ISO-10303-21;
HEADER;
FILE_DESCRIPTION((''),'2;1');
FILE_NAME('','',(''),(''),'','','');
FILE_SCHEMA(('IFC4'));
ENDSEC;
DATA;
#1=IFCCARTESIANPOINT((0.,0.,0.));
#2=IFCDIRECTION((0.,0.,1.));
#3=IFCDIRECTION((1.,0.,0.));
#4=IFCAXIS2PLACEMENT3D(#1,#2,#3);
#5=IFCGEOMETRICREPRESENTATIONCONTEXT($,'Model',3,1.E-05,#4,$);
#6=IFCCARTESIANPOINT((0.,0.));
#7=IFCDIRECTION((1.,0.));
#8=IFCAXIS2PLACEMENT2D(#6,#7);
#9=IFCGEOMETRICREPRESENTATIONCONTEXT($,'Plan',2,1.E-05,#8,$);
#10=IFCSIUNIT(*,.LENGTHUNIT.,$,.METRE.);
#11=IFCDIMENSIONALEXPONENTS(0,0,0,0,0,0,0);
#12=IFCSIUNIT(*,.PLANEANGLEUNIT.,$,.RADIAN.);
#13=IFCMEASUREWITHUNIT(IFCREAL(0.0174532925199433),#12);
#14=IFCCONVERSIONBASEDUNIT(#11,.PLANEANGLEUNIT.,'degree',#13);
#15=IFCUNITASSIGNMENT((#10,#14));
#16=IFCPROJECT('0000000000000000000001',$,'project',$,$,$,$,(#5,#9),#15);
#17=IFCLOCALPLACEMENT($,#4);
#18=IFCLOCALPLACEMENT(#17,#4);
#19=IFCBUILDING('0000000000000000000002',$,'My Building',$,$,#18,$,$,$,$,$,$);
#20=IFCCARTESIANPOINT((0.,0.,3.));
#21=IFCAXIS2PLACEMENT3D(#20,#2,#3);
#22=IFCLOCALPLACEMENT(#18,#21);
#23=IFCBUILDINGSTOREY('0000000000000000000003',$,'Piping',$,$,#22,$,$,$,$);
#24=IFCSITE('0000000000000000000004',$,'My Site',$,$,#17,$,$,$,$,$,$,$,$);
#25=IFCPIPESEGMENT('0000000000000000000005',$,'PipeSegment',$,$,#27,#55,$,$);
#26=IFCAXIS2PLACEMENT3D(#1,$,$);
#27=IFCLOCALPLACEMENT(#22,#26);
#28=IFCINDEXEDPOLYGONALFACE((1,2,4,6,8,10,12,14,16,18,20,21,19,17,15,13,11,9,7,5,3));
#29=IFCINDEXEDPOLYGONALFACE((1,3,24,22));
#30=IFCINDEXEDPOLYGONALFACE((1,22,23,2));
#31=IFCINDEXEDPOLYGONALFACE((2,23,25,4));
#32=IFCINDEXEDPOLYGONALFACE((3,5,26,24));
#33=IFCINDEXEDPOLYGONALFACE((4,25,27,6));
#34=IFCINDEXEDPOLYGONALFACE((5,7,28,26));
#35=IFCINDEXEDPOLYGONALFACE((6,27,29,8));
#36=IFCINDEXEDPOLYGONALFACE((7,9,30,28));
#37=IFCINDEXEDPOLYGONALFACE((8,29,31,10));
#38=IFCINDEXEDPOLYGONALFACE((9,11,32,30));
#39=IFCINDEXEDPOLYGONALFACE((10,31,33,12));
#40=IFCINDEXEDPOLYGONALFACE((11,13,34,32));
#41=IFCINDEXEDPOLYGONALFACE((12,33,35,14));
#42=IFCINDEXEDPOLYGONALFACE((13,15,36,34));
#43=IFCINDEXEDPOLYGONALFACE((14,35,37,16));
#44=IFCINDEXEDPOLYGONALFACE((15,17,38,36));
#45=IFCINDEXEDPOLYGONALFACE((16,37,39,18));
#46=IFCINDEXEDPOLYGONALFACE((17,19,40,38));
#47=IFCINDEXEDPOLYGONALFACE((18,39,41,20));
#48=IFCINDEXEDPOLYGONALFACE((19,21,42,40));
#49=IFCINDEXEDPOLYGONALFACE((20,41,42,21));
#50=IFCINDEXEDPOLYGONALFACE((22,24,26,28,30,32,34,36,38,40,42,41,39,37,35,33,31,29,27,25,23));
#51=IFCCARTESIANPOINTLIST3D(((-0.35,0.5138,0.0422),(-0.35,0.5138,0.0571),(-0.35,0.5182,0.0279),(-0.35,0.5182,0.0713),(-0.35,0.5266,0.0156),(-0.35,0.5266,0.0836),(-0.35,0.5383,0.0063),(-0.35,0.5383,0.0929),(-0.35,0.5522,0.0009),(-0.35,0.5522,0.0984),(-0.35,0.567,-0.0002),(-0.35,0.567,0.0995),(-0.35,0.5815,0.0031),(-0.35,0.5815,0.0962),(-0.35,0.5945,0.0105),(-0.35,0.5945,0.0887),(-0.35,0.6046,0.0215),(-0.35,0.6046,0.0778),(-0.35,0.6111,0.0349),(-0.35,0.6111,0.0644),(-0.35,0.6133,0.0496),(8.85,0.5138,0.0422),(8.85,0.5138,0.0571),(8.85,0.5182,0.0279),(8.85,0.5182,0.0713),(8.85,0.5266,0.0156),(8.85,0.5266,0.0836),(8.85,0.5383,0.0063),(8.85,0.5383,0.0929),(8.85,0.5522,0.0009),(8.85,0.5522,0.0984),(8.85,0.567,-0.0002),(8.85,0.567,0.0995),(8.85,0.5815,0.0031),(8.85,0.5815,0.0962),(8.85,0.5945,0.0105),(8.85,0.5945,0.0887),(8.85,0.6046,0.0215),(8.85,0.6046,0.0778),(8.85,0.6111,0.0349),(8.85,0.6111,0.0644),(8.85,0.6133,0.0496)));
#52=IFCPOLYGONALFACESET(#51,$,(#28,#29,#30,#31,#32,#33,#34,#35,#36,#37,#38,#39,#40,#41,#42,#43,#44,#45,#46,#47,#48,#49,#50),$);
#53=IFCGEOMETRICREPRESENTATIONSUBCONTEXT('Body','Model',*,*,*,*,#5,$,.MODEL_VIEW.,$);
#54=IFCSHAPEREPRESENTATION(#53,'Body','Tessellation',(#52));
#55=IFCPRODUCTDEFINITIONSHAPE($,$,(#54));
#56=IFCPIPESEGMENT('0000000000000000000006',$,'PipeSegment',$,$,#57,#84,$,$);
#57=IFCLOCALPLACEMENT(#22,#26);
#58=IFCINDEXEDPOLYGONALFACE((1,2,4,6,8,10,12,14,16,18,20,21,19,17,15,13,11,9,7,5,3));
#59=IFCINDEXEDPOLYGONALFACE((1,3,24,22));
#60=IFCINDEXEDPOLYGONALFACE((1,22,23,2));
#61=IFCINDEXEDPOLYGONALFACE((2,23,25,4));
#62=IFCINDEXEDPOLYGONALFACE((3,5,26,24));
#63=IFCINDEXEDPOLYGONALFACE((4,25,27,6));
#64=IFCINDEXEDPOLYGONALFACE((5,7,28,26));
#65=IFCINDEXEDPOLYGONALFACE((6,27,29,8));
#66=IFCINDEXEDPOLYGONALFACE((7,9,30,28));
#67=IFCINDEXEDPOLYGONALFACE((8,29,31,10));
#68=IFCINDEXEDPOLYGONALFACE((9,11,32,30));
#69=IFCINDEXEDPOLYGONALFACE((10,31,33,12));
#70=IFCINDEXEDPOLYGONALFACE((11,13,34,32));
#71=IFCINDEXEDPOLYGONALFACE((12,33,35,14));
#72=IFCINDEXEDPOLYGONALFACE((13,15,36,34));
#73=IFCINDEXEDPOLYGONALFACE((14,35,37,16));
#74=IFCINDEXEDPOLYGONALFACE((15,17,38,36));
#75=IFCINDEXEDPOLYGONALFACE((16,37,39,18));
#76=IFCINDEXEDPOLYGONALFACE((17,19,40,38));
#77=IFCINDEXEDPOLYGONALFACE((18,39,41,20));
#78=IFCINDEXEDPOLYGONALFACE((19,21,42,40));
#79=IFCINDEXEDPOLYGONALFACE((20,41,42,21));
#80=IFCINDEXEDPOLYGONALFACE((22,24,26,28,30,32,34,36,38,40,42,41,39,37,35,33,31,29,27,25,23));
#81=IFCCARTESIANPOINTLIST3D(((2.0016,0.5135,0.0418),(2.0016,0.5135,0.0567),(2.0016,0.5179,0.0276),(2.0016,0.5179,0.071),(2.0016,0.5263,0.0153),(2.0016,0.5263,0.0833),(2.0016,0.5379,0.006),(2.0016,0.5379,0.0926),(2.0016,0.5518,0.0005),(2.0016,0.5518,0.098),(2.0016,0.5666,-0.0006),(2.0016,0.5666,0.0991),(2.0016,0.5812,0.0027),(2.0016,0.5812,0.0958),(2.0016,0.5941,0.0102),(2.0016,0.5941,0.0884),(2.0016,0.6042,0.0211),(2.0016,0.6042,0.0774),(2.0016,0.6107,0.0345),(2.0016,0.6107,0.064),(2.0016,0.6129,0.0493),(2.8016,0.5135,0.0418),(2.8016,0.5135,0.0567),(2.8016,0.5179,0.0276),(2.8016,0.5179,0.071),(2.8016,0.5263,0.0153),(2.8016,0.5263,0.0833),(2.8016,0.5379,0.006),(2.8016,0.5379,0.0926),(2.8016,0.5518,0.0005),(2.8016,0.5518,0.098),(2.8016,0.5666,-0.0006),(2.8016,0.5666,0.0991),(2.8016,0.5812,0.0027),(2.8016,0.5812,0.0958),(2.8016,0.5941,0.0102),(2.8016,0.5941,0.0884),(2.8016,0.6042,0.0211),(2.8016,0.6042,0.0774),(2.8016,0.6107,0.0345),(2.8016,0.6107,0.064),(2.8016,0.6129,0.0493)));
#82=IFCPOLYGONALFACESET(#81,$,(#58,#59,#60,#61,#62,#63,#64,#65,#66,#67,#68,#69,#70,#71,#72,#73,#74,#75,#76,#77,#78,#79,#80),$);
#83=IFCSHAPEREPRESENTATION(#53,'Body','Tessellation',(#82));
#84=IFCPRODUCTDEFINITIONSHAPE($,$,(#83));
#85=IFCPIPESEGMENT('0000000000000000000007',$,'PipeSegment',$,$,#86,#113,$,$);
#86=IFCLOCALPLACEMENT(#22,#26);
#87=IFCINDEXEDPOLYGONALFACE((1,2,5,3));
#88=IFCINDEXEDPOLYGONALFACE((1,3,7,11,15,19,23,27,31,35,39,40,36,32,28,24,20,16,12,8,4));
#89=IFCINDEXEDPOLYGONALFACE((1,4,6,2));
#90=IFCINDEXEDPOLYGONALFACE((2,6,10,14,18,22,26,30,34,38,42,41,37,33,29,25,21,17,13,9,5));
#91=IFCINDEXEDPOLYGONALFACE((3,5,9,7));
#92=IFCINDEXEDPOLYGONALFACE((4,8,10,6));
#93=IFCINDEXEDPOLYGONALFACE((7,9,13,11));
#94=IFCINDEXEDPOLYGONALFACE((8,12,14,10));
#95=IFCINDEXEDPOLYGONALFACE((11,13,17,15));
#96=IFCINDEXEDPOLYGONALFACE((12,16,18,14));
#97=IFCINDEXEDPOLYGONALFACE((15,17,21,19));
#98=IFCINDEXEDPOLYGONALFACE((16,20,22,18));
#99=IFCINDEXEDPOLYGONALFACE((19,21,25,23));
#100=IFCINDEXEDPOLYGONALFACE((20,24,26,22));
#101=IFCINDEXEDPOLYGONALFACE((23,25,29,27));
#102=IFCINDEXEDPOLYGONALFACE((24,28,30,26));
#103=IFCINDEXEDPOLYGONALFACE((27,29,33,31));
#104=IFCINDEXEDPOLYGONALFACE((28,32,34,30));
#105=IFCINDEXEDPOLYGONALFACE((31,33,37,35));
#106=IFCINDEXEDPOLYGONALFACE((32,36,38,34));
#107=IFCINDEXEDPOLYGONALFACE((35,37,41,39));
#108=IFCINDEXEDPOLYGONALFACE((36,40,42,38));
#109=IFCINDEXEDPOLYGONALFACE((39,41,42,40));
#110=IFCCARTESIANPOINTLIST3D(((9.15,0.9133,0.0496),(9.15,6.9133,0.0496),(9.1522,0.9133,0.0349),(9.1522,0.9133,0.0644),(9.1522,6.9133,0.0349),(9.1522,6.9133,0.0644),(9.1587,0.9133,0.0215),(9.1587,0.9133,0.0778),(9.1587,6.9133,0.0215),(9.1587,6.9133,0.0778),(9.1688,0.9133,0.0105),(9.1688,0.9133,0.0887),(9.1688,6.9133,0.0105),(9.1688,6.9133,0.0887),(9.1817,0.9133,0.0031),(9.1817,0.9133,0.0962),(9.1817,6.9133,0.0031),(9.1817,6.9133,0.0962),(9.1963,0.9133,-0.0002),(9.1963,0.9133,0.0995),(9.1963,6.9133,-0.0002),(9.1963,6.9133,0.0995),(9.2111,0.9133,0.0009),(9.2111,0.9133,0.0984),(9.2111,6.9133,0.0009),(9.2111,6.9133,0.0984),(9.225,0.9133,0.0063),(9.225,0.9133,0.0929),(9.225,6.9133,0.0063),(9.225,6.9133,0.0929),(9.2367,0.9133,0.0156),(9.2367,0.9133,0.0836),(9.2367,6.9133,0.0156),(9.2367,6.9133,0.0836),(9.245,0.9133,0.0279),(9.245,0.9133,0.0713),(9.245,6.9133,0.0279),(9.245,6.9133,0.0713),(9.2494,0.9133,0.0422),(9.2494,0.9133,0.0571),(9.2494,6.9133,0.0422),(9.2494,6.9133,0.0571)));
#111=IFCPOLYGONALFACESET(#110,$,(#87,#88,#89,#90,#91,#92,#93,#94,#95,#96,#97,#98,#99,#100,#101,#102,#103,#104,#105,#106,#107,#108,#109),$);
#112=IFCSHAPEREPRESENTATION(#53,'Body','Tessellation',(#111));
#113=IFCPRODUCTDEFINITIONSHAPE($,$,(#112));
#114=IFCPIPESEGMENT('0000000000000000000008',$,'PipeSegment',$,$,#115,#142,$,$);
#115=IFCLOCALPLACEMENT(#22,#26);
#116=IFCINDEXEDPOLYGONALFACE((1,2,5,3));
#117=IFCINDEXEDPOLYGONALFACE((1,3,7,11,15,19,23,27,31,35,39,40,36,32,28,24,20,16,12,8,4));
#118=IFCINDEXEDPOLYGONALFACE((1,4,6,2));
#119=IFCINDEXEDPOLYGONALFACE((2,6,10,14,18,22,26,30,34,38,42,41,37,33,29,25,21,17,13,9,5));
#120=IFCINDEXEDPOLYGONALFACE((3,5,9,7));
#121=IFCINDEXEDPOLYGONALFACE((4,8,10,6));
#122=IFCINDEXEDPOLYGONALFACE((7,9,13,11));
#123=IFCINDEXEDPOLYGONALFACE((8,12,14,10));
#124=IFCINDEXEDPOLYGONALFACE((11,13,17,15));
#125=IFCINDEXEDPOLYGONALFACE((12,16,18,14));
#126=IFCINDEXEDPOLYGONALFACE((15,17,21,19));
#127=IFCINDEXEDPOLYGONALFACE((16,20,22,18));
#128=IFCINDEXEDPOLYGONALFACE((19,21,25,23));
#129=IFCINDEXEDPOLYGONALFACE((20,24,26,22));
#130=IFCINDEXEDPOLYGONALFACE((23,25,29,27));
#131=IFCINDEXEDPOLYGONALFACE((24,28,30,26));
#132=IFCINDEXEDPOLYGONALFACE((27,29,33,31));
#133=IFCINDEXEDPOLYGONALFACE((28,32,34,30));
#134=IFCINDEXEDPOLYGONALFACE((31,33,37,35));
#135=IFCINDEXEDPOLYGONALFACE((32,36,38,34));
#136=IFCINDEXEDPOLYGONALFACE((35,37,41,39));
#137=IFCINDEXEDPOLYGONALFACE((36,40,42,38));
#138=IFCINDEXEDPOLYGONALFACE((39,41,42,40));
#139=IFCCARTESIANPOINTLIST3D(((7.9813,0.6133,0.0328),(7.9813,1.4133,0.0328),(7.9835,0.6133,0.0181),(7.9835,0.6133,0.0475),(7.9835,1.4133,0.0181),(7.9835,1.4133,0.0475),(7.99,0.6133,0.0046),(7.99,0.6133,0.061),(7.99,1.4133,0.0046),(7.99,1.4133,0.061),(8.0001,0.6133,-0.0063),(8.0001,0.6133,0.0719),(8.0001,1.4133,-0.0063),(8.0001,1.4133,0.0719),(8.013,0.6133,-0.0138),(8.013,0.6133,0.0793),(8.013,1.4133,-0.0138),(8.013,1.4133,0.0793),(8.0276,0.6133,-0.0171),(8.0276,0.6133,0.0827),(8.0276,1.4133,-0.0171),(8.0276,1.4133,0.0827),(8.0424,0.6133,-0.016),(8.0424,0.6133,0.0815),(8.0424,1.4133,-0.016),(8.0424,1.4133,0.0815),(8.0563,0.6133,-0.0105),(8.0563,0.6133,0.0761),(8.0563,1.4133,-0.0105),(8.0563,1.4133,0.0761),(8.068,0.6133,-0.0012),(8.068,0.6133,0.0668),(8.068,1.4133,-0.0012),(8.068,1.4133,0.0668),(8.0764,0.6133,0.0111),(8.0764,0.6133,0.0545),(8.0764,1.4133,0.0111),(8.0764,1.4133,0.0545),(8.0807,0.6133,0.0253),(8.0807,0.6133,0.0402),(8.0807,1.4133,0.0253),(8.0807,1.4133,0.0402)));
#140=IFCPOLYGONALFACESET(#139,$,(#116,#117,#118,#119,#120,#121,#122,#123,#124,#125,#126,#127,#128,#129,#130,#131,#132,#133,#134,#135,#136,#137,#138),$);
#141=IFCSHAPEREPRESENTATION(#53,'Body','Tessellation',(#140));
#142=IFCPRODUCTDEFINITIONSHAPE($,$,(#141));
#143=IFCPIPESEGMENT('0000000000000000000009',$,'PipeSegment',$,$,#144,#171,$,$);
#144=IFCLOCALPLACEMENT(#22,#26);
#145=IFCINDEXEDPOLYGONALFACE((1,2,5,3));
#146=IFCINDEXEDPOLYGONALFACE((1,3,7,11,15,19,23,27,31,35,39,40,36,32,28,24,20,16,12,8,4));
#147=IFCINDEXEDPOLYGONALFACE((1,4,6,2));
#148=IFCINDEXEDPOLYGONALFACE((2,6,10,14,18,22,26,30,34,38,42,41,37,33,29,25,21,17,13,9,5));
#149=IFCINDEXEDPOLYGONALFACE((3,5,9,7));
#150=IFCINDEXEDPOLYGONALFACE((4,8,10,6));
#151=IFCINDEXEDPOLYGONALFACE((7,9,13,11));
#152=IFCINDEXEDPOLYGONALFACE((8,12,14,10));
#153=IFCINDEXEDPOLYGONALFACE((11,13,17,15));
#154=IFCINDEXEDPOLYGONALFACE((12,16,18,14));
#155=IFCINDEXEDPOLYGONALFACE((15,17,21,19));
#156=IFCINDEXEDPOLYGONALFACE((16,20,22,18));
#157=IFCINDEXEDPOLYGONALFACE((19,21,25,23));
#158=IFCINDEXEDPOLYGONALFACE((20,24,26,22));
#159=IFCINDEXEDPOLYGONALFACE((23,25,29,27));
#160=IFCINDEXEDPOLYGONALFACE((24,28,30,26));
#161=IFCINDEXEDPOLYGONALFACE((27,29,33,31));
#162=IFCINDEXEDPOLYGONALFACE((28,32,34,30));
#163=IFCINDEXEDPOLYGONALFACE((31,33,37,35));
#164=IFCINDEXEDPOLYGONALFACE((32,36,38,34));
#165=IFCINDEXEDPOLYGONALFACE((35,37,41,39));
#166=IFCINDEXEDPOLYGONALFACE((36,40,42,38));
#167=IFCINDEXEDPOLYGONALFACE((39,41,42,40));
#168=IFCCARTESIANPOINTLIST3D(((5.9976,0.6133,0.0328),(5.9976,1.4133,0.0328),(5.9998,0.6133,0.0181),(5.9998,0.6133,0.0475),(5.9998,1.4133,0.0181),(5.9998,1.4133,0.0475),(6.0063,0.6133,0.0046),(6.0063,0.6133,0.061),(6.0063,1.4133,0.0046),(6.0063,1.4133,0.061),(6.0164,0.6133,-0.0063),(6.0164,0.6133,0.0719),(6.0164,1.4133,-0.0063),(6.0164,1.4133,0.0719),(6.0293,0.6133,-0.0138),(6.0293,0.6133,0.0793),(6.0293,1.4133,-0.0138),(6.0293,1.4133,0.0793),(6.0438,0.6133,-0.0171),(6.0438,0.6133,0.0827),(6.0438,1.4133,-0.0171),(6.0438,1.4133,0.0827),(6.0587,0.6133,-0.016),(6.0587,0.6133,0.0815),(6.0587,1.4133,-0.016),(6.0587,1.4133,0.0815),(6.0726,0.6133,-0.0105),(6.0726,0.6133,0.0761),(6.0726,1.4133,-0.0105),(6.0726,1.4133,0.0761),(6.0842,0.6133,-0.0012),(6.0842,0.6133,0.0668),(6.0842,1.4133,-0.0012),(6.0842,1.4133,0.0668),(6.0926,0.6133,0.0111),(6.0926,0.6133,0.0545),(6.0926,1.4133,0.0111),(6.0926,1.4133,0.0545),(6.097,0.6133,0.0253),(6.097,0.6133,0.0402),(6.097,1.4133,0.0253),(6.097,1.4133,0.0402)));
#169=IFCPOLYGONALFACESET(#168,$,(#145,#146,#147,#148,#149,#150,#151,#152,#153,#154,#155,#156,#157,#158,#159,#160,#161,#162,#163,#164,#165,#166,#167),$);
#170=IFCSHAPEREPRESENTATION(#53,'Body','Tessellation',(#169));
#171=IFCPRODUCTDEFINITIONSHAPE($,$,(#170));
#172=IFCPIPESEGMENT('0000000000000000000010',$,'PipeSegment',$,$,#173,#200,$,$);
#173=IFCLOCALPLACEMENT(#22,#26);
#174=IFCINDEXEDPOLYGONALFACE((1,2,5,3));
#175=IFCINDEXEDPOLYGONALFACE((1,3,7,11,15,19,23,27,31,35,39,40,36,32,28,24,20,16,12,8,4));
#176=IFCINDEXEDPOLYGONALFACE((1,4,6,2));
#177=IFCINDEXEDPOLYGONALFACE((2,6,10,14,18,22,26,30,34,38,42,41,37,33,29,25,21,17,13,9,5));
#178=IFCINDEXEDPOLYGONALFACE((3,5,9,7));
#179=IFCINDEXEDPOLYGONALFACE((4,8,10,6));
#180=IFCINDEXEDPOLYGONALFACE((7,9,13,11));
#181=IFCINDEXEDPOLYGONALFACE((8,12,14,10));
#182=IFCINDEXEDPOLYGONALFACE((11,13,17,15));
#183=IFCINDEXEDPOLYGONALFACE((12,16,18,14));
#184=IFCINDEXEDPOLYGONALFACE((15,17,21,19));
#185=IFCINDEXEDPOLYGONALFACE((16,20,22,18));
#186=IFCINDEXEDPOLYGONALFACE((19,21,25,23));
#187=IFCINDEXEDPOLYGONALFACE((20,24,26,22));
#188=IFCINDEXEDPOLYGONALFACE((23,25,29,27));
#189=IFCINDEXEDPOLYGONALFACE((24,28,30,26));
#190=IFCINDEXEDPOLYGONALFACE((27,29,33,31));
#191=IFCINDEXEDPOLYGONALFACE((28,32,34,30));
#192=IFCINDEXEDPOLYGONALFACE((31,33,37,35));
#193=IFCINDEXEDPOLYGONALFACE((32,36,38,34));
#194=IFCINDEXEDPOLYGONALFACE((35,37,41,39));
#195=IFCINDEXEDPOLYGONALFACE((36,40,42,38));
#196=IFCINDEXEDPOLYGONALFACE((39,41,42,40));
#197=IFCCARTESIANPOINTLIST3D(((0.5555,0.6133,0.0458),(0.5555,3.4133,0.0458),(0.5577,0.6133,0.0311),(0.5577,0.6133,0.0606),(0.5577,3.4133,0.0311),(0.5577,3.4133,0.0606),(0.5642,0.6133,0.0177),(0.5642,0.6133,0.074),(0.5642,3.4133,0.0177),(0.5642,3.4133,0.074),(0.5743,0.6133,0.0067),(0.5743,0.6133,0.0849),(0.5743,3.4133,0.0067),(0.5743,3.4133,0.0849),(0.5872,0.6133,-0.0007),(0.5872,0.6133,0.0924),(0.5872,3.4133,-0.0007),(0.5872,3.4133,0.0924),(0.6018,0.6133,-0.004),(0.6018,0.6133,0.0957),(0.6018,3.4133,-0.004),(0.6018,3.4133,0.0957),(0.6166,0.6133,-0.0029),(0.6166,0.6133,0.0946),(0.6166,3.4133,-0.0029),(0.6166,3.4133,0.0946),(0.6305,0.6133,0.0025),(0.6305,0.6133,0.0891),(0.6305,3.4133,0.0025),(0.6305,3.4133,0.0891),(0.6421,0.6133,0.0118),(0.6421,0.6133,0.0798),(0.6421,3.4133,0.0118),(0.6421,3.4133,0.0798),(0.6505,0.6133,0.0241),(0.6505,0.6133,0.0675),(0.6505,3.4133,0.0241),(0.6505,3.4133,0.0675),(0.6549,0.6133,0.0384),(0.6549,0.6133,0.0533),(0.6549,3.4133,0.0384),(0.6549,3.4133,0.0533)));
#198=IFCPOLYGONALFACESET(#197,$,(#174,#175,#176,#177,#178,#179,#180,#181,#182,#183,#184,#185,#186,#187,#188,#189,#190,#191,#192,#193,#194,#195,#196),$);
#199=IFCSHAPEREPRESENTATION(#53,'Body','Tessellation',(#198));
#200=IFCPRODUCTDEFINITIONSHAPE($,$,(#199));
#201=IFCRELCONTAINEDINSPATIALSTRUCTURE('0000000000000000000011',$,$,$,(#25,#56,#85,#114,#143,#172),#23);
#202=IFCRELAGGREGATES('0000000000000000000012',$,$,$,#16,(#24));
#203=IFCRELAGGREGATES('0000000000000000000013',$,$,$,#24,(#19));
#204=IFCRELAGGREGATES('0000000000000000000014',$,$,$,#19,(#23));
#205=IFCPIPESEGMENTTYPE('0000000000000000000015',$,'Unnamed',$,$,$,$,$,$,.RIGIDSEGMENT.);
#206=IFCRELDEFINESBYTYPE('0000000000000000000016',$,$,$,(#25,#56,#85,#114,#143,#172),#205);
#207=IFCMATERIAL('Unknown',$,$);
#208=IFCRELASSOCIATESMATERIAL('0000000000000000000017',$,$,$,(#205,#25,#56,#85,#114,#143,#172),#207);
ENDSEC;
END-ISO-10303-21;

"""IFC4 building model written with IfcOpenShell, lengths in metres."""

from ifc_helpers import new_model, entity, si_unit, converted_unit, frame, origin_with_axes, origin_2d_with_axis, place, context, subcontext, project, spatial, circle, extrude, material, material_profile, profile_set, profile_usage, type_object, element, save


model = new_model("IFC4")

# Units and contexts
model_context = context("Model", 3, precision=1e-05, world=origin_with_axes())
plan_context = context("Plan", 2, precision=1e-05, world=origin_2d_with_axis())
body_context = subcontext(model_context, "Body", "Model", "MODEL_VIEW")
ifc_project = project(units=[si_unit("LENGTHUNIT", "METRE"), converted_unit("PLANEANGLEUNIT", "degree", entity("IfcReal", 0.0174532925199433), si_unit("PLANEANGLEUNIT", "RADIAN"), dimensions=[0, 0, 0, 0, 0, 0, 0])], contexts=[model_context, plan_context])

# Site, building, storey
site_placement = place(None, origin_with_axes())
site = spatial("IfcSite", under=ifc_project, at=site_placement, Name="My Site")
building_placement = place(site_placement, origin_with_axes())
building = spatial("IfcBuilding", under=site, at=building_placement, Name="My Building")
storey_placement = place(building_placement, frame((0.0, 0.0, 3.0), z_axis=(0.0, 0.0, 1.0), x_axis=(1.0, 0.0, 0.0)))
storey = spatial("IfcBuildingStorey", under=building, at=storey_placement, Name="Piping")

# Pipe segments
ifc_material = material(Name="Unknown")
ifc_material_profile = material_profile(ifc_material, circle(Radius=0.05))
ifc_profile_set = profile_set([ifc_material_profile])
ifc_profile_usage_1 = profile_usage(ifc_profile_set, cardinal=5)
pipe_segment_type = type_object("IfcPipeSegmentType", Name="Unnamed", PredefinedType="RIGIDSEGMENT", material=ifc_profile_set)
pipe_segment_1_placement = place(storey_placement, frame((-0.35, 0.5633, 0.0496), z_axis=(1.0, 0.0, 0.0), x_axis=(0.0, 1.0, 0.0)))
element("IfcPipeSegment", 1, at=pipe_segment_1_placement, inside=storey, type_object=pipe_segment_type, material=ifc_profile_usage_1, Name="PipeSegment", context=body_context, shape_type="SweptSolid", body=[
    extrude(circle(Radius=0.05), origin_with_axes(), (0.0, 0.0, 1.0), 9.2),
])
ifc_profile_usage_2 = profile_usage(ifc_profile_set, cardinal=8)
pipe_segment_2_placement = place(storey_placement, frame((2.0016, 0.5629, 0.0993), z_axis=(1.0, 0.0, 0.0), x_axis=(0.0, 1.0, 0.0)))
element("IfcPipeSegment", 2, at=pipe_segment_2_placement, inside=storey, type_object=pipe_segment_type, material=ifc_profile_usage_2, Name="PipeSegment", context=body_context, shape_type="SweptSolid", body=[
    extrude(circle(Radius=0.05), frame((0.0, -0.05, 0.0), z_axis=(0.0, 0.0, 1.0), x_axis=(1.0, 0.0, 0.0)), (0.0, 0.0, 1.0), 0.8),
])
ifc_profile_usage_3 = profile_usage(ifc_profile_set, cardinal=10)
pipe_segment_3_placement = place(storey_placement, frame((9.2, 0.9133, 0.0496), z_axis=(0.0, 1.0, 0.0), x_axis=(-1.0, 0.0, 0.0)))
element("IfcPipeSegment", 3, at=pipe_segment_3_placement, inside=storey, type_object=pipe_segment_type, material=ifc_profile_usage_3, Name="PipeSegment", context=body_context, shape_type="SweptSolid", body=[
    extrude(circle(Radius=0.05), origin_with_axes(), (0.0, 0.0, 1.0), 6.0),
])
ifc_profile_usage_4 = profile_usage(ifc_profile_set, cardinal=8)
pipe_segment_4_placement = place(storey_placement, frame((8.0313, 0.6133, 0.0828), z_axis=(0.0, 1.0, 0.0), x_axis=(-1.0, 0.0, 0.0)))
element("IfcPipeSegment", 4, at=pipe_segment_4_placement, inside=storey, type_object=pipe_segment_type, material=ifc_profile_usage_4, Name="PipeSegment", context=body_context, shape_type="SweptSolid", body=[
    extrude(circle(Radius=0.05), frame((0.0, -0.05, 0.0), z_axis=(0.0, 0.0, 1.0), x_axis=(1.0, 0.0, 0.0)), (0.0, 0.0, 1.0), 0.8),
])
ifc_profile_usage_5 = profile_usage(ifc_profile_set, cardinal=8)
pipe_segment_5_placement = place(storey_placement, frame((6.0476, 0.6133, 0.0828), z_axis=(0.0, 1.0, 0.0), x_axis=(-1.0, 0.0, 0.0)))
element("IfcPipeSegment", 5, at=pipe_segment_5_placement, inside=storey, type_object=pipe_segment_type, material=ifc_profile_usage_5, Name="PipeSegment", context=body_context, shape_type="SweptSolid", body=[
    extrude(circle(Radius=0.05), frame((0.0, -0.05, 0.0), z_axis=(0.0, 0.0, 1.0), x_axis=(1.0, 0.0, 0.0)), (0.0, 0.0, 1.0), 0.8),
])
ifc_profile_usage_6 = profile_usage(ifc_profile_set, cardinal=10)
pipe_segment_6_placement = place(storey_placement, frame((0.6055, 0.6133, 0.0458), z_axis=(0.0, 1.0, 0.0), x_axis=(-1.0, 0.0, 0.0)))
element("IfcPipeSegment", 6, at=pipe_segment_6_placement, inside=storey, type_object=pipe_segment_type, material=ifc_profile_usage_6, Name="PipeSegment", context=body_context, shape_type="SweptSolid", body=[
    extrude(circle(Radius=0.05), origin_with_axes(), (0.0, 0.0, 1.0), 2.8),
])

save(model, "model.ifc")
